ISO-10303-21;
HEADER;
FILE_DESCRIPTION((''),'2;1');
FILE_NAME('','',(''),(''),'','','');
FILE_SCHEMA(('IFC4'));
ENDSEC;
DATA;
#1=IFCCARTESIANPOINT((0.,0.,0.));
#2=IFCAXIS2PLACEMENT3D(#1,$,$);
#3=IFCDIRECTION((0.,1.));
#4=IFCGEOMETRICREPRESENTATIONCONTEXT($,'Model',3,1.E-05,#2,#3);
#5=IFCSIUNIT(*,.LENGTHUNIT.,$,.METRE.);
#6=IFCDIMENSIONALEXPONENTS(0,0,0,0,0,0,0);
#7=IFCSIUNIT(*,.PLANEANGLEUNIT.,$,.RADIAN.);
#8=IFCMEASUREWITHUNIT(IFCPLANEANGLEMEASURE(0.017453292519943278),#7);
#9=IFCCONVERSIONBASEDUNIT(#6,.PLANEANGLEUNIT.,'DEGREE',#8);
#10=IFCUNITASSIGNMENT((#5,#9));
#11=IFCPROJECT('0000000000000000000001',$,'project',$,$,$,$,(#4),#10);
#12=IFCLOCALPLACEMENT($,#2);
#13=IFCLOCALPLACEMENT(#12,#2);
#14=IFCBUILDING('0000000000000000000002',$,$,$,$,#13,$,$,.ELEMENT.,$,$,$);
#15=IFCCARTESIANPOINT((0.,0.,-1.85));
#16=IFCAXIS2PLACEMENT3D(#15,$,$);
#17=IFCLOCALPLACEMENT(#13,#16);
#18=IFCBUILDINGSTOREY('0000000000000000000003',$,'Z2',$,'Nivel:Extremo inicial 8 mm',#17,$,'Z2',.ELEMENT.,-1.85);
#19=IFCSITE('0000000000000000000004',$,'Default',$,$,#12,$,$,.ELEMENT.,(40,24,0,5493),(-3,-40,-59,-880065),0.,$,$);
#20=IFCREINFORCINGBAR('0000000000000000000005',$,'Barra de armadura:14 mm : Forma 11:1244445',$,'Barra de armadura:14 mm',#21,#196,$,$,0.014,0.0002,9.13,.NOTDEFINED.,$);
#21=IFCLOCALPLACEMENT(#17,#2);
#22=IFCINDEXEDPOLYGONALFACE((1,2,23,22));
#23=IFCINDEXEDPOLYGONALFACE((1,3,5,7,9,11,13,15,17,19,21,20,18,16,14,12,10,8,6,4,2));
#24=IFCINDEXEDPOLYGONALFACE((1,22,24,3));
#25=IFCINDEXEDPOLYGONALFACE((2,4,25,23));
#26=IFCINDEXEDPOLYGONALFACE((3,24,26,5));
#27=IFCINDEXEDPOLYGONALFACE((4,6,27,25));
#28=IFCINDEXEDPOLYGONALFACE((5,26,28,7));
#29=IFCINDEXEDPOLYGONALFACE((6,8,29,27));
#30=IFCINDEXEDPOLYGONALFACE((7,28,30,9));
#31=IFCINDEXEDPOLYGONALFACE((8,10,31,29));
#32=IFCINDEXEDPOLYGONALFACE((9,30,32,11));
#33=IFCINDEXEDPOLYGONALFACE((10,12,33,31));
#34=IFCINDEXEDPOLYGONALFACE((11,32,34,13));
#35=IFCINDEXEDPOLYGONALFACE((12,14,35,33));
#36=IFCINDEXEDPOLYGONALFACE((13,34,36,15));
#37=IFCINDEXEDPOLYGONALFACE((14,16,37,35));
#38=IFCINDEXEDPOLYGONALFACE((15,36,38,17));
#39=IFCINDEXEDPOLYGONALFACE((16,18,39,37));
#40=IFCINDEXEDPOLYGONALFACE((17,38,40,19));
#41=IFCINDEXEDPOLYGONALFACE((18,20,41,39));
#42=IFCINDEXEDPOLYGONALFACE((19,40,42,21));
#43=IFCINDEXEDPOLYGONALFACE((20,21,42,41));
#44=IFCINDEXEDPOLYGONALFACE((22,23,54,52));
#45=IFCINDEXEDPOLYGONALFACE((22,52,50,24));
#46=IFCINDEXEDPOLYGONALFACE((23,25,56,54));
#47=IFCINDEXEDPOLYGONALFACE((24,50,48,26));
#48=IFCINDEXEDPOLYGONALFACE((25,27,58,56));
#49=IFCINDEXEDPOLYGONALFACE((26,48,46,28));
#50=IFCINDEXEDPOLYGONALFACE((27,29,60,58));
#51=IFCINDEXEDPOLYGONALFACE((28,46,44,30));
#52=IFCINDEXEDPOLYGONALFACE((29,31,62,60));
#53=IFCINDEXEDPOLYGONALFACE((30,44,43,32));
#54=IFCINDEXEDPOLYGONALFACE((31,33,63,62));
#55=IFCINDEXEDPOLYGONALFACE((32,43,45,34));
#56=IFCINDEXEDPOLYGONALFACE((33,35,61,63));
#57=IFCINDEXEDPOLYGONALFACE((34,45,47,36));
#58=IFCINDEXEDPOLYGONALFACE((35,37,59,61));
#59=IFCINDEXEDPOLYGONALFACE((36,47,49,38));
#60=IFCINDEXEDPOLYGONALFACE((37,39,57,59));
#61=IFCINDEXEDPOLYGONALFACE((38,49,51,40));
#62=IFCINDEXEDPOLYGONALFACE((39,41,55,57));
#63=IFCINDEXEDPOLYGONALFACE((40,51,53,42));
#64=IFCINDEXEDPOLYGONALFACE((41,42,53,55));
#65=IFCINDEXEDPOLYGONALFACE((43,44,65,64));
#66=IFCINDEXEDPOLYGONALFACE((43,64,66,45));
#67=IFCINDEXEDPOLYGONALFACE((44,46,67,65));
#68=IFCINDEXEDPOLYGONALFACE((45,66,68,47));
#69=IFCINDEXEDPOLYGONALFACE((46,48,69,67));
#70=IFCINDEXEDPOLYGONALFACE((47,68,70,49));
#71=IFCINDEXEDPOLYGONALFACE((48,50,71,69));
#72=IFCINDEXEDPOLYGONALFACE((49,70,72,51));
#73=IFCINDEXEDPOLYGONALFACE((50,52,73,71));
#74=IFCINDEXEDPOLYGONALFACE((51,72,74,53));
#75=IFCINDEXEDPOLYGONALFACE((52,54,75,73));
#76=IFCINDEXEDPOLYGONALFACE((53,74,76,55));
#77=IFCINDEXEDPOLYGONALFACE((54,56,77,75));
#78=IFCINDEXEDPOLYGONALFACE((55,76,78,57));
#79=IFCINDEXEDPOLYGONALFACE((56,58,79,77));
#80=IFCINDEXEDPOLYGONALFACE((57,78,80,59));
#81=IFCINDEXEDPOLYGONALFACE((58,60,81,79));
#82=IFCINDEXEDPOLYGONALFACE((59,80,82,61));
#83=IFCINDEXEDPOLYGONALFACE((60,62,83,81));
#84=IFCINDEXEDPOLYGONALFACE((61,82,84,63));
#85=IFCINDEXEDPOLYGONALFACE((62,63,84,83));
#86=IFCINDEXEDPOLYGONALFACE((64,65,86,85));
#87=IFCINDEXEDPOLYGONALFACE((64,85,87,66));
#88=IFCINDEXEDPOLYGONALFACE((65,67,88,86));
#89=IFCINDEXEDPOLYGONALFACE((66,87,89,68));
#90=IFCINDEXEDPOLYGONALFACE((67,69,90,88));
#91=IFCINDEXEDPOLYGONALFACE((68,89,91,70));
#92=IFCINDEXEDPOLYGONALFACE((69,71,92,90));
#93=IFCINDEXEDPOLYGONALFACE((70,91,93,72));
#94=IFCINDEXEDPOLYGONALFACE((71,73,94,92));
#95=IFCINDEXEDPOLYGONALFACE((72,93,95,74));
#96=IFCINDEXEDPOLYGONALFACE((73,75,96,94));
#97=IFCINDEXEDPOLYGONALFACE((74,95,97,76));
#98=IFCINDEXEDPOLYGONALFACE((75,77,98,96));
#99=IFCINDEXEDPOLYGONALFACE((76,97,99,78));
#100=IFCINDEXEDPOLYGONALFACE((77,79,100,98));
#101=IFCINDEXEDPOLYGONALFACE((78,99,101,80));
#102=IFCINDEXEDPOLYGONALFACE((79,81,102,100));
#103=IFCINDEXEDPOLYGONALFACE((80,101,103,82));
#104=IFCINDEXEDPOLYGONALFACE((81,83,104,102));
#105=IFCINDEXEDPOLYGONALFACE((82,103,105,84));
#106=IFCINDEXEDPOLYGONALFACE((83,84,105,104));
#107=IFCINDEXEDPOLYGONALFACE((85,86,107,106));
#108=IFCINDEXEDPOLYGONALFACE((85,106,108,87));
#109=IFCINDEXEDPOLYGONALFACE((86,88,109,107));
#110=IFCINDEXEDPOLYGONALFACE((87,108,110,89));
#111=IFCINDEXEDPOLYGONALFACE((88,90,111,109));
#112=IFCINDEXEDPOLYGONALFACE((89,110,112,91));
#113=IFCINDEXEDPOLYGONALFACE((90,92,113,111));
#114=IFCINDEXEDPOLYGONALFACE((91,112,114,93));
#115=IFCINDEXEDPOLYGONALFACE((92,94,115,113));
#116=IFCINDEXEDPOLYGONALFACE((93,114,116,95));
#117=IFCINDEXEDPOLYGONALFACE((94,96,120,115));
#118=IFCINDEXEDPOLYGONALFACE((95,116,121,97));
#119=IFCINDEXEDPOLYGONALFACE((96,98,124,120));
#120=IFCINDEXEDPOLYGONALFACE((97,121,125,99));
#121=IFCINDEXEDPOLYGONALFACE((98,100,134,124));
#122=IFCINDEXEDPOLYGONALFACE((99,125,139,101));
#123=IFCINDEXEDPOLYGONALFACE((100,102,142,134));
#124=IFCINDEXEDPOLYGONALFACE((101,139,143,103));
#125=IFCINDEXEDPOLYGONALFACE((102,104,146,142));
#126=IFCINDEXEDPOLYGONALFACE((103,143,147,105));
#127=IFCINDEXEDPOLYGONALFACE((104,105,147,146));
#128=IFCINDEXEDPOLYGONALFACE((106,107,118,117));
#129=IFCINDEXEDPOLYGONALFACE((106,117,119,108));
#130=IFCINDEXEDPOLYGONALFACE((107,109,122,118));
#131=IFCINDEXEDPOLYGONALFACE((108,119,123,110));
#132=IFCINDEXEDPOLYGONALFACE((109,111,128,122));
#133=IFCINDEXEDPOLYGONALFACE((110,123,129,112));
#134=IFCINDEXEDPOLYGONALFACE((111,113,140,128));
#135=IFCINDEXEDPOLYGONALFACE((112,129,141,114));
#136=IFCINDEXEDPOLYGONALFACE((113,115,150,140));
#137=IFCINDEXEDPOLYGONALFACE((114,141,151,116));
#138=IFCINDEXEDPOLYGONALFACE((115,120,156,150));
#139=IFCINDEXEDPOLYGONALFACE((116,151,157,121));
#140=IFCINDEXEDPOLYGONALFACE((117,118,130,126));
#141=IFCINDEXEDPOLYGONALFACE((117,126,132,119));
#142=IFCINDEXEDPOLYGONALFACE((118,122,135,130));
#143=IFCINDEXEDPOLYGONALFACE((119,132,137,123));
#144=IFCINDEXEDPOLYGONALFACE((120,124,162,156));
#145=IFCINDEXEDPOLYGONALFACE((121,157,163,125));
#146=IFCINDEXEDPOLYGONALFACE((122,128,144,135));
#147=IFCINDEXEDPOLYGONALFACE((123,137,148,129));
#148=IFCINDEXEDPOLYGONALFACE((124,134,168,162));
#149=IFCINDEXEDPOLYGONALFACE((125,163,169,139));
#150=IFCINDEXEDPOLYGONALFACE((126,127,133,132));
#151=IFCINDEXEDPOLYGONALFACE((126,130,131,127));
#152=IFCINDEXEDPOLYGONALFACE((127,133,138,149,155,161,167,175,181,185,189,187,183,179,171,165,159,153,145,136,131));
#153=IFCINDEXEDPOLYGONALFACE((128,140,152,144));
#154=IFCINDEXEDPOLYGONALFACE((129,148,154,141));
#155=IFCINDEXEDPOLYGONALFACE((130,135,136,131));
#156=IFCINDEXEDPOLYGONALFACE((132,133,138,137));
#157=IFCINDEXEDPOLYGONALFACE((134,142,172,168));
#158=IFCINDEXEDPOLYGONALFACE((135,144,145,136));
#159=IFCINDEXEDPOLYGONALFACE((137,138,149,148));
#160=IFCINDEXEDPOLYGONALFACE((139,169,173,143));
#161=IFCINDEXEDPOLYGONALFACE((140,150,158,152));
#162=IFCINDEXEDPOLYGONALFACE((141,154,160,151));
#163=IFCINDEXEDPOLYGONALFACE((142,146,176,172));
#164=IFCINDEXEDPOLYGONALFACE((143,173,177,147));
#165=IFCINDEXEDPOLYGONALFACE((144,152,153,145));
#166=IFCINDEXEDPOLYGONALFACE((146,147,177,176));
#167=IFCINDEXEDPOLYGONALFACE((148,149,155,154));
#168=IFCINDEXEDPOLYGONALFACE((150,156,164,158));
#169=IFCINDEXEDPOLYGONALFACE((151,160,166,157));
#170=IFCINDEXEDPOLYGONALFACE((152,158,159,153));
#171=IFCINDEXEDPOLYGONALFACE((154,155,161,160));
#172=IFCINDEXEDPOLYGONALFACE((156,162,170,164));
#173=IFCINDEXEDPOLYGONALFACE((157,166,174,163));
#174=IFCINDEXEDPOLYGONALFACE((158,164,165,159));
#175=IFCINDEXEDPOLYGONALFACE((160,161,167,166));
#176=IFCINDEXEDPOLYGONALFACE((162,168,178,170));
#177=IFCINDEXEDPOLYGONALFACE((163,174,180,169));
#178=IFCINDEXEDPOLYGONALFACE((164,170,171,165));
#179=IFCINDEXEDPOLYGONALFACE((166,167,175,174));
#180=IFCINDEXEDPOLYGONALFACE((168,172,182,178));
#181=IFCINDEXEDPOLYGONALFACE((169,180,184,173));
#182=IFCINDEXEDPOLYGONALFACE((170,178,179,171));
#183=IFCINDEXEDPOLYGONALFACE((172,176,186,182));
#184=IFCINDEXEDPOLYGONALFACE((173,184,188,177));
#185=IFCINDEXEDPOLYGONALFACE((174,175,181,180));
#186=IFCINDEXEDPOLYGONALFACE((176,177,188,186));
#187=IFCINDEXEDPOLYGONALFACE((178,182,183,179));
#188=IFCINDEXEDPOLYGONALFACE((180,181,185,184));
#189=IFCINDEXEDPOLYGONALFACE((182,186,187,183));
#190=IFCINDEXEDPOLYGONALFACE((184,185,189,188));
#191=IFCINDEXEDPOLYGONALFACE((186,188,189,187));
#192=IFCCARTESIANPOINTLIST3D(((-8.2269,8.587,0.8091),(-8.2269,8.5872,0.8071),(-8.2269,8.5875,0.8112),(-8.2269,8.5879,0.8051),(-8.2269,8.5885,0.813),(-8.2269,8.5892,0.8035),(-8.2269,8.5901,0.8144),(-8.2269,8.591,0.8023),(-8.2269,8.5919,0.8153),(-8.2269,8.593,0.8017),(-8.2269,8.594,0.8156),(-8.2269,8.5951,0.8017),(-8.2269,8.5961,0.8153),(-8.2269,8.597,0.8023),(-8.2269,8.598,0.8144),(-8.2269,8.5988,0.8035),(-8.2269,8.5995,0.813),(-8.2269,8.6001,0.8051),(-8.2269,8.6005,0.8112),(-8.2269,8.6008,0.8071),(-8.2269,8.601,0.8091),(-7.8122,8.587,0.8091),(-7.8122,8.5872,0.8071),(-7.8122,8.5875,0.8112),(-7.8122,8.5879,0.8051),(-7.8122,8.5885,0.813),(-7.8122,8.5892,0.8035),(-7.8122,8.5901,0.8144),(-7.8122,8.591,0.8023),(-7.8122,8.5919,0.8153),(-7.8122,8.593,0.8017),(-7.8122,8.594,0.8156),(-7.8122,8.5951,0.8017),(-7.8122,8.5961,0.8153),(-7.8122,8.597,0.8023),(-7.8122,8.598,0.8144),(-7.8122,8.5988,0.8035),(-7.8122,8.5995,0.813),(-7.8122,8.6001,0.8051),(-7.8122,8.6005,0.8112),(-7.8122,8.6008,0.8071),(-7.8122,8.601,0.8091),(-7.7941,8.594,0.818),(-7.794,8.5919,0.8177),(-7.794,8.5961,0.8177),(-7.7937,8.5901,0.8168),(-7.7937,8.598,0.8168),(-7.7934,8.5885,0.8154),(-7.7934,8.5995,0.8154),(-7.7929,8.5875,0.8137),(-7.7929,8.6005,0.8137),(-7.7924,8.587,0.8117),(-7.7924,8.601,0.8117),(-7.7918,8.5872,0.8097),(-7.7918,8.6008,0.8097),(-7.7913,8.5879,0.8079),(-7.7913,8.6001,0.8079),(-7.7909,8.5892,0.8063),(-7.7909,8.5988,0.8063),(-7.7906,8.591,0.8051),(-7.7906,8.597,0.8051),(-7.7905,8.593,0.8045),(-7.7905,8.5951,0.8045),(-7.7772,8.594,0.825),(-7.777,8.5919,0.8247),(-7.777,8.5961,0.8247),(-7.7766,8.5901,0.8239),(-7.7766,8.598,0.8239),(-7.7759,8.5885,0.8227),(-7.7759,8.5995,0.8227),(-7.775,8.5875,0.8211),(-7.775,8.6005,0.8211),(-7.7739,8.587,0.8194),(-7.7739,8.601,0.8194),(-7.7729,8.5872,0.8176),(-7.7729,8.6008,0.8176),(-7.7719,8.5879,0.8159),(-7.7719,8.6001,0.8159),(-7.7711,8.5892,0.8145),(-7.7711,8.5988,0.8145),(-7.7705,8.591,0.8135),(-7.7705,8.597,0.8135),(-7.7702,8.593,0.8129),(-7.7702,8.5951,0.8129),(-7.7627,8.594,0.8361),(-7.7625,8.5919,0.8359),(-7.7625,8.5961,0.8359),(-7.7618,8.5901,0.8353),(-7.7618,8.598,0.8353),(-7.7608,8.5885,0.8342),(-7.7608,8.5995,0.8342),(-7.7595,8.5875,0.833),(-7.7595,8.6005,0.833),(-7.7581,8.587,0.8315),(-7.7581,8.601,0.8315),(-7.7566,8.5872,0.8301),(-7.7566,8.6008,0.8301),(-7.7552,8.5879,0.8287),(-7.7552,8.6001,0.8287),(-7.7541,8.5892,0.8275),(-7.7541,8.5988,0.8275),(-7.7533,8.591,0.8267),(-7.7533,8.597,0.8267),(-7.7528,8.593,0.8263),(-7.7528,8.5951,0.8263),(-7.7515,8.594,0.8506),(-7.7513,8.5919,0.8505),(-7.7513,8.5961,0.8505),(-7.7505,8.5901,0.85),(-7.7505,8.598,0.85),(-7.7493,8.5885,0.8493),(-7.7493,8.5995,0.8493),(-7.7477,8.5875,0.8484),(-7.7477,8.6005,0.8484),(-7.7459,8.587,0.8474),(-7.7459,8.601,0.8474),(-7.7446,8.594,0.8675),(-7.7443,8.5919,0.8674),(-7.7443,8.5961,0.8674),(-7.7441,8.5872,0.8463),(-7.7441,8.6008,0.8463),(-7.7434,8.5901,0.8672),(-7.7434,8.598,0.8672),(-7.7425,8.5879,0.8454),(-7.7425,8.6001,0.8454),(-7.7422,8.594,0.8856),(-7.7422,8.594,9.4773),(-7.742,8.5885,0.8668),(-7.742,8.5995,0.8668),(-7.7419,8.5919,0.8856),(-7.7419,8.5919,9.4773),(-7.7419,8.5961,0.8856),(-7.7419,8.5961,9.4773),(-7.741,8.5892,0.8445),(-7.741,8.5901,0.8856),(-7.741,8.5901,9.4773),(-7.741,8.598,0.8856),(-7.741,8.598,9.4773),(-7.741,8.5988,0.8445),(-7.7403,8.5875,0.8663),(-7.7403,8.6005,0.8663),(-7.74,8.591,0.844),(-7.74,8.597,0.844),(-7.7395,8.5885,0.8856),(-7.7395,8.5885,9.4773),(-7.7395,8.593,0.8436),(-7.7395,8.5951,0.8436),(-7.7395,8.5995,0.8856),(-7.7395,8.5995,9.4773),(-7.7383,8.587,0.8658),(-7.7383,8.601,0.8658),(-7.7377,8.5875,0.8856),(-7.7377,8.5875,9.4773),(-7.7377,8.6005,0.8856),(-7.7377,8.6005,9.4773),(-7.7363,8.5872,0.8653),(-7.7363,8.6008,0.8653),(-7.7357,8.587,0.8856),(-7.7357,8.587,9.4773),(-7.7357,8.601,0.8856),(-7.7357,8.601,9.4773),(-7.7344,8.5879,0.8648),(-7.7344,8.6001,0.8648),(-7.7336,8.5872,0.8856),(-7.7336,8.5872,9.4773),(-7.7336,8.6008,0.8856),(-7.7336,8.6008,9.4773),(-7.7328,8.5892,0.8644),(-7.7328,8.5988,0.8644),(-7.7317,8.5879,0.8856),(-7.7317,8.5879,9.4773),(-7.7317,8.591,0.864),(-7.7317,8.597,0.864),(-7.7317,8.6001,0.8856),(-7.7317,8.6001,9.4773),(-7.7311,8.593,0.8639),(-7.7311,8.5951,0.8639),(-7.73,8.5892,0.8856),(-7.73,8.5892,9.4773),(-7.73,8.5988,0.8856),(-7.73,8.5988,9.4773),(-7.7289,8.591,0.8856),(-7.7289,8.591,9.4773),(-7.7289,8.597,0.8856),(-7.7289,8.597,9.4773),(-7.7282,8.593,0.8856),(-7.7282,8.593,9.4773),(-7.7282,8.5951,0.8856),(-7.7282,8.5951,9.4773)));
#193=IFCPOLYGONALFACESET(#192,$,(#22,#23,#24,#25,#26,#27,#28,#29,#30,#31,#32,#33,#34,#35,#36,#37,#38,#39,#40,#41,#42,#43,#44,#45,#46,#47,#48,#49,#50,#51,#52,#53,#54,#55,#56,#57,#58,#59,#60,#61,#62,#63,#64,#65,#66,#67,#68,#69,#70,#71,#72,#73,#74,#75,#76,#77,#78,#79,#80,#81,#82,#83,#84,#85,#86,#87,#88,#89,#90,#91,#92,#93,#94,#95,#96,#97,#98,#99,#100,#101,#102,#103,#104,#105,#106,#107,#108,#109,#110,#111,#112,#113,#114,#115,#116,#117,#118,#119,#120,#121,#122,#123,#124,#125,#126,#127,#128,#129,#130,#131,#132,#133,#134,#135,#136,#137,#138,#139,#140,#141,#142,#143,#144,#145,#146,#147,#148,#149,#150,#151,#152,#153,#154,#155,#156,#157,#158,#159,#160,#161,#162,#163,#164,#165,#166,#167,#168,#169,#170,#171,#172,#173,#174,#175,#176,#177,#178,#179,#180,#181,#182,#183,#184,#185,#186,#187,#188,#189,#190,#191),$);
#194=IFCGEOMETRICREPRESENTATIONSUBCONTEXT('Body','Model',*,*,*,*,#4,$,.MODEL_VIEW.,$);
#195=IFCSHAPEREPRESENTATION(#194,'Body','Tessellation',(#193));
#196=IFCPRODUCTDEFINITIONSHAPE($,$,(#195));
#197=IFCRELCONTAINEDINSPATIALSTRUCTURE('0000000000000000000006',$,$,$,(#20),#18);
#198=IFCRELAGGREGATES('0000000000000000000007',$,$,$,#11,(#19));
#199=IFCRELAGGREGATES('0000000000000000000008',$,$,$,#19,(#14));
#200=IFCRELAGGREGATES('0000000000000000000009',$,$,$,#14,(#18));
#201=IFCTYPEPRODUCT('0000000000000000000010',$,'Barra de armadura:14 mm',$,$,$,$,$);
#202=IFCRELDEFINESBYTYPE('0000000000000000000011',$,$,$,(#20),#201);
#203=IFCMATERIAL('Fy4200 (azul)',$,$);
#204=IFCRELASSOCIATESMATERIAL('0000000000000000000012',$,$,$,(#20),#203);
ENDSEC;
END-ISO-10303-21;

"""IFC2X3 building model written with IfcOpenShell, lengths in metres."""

from ifc_helpers import new_model, entity, si_unit, converted_unit, direction, frame, origin, place, context, subcontext, project, spatial, material, type_object, element, save


model = new_model("IFC2X3")

# Units and contexts
model_context = context("Model", 3, precision=1e-05, world=origin(), true_north=direction((0.0, 1.0)))
body_context = subcontext(model_context, "Body", "Model", "MODEL_VIEW")
ifc_project = project(units=[si_unit("LENGTHUNIT", "METRE"), converted_unit("PLANEANGLEUNIT", "DEGREE", entity("IfcPlaneAngleMeasure", 0.017453292519943278), si_unit("PLANEANGLEUNIT", "RADIAN"), dimensions=[0, 0, 0, 0, 0, 0, 0])], contexts=[model_context])

# Site, building, storey
site_placement = place(None, origin())
site = spatial("IfcSite", under=ifc_project, at=site_placement, Name="Default", CompositionType="ELEMENT", RefLatitude=(40, 24, 0, 5493), RefLongitude=(-3, -40, -59, -880065), RefElevation=0.0)
building_placement = place(site_placement, origin())
building = spatial("IfcBuilding", under=site, at=building_placement, CompositionType="ELEMENT")
storey_placement = place(building_placement, frame((0.0, 0.0, -1.85)))
storey = spatial("IfcBuildingStorey", under=building, at=storey_placement, Name="Z2", ObjectType="Nivel:Extremo inicial 8 mm", LongName="Z2", CompositionType="ELEMENT", Elevation=-1.85)

# Reinforcing bar
ifc_material_1 = material(Name="Fy4200 (azul)")
type_product_1 = type_object("IfcTypeProduct", Name="Barra de armadura:14 mm")
reinforcing_bar_1_placement = place(storey_placement, origin())
element("IfcReinforcingBar", 1, at=reinforcing_bar_1_placement, inside=storey, type_object=type_product_1, material=ifc_material_1, Name="Barra de armadura:14 mm : Forma 11:1244445", ObjectType="Barra de armadura:14 mm", BarLength=9.13, BarRole="NOTDEFINED", CrossSectionArea=0.0002, NominalDiameter=0.014, context=body_context, shape_type="AdvancedSweptSolid", body=[
    entity("IfcSweptDiskSolid", entity("IfcCompositeCurve", [entity("IfcCompositeCurveSegment", "CONTINUOUS", True, entity("IfcPolyline", [entity("IfcCartesianPoint", [-7.7352, 8.594, 9.4773]), entity("IfcCartesianPoint", [-7.7352, 8.594, 0.8856])])), entity("IfcCompositeCurveSegment", "CONTINUOUS", True, entity("IfcTrimmedCurve", entity("IfcCircle", entity("IfcAxis2Placement3D", entity("IfcCartesianPoint", [-7.8122, 8.594, 0.8856]), entity("IfcDirection", [0.0, 1.0, 0.0]), entity("IfcDirection", [0.0, 0.0, -1.0])), 0.077), [entity("IfcParameterValue", 270.0)], [entity("IfcParameterValue", 360.0)], True, "PARAMETER")), entity("IfcCompositeCurveSegment", "CONTINUOUS", True, entity("IfcPolyline", [entity("IfcCartesianPoint", [-7.8122, 8.594, 0.8086]), entity("IfcCartesianPoint", [-8.2269, 8.594, 0.8086])]))], False), 0.007, None, 0.0, 92.0),
])

save(model, "model.ifc")
